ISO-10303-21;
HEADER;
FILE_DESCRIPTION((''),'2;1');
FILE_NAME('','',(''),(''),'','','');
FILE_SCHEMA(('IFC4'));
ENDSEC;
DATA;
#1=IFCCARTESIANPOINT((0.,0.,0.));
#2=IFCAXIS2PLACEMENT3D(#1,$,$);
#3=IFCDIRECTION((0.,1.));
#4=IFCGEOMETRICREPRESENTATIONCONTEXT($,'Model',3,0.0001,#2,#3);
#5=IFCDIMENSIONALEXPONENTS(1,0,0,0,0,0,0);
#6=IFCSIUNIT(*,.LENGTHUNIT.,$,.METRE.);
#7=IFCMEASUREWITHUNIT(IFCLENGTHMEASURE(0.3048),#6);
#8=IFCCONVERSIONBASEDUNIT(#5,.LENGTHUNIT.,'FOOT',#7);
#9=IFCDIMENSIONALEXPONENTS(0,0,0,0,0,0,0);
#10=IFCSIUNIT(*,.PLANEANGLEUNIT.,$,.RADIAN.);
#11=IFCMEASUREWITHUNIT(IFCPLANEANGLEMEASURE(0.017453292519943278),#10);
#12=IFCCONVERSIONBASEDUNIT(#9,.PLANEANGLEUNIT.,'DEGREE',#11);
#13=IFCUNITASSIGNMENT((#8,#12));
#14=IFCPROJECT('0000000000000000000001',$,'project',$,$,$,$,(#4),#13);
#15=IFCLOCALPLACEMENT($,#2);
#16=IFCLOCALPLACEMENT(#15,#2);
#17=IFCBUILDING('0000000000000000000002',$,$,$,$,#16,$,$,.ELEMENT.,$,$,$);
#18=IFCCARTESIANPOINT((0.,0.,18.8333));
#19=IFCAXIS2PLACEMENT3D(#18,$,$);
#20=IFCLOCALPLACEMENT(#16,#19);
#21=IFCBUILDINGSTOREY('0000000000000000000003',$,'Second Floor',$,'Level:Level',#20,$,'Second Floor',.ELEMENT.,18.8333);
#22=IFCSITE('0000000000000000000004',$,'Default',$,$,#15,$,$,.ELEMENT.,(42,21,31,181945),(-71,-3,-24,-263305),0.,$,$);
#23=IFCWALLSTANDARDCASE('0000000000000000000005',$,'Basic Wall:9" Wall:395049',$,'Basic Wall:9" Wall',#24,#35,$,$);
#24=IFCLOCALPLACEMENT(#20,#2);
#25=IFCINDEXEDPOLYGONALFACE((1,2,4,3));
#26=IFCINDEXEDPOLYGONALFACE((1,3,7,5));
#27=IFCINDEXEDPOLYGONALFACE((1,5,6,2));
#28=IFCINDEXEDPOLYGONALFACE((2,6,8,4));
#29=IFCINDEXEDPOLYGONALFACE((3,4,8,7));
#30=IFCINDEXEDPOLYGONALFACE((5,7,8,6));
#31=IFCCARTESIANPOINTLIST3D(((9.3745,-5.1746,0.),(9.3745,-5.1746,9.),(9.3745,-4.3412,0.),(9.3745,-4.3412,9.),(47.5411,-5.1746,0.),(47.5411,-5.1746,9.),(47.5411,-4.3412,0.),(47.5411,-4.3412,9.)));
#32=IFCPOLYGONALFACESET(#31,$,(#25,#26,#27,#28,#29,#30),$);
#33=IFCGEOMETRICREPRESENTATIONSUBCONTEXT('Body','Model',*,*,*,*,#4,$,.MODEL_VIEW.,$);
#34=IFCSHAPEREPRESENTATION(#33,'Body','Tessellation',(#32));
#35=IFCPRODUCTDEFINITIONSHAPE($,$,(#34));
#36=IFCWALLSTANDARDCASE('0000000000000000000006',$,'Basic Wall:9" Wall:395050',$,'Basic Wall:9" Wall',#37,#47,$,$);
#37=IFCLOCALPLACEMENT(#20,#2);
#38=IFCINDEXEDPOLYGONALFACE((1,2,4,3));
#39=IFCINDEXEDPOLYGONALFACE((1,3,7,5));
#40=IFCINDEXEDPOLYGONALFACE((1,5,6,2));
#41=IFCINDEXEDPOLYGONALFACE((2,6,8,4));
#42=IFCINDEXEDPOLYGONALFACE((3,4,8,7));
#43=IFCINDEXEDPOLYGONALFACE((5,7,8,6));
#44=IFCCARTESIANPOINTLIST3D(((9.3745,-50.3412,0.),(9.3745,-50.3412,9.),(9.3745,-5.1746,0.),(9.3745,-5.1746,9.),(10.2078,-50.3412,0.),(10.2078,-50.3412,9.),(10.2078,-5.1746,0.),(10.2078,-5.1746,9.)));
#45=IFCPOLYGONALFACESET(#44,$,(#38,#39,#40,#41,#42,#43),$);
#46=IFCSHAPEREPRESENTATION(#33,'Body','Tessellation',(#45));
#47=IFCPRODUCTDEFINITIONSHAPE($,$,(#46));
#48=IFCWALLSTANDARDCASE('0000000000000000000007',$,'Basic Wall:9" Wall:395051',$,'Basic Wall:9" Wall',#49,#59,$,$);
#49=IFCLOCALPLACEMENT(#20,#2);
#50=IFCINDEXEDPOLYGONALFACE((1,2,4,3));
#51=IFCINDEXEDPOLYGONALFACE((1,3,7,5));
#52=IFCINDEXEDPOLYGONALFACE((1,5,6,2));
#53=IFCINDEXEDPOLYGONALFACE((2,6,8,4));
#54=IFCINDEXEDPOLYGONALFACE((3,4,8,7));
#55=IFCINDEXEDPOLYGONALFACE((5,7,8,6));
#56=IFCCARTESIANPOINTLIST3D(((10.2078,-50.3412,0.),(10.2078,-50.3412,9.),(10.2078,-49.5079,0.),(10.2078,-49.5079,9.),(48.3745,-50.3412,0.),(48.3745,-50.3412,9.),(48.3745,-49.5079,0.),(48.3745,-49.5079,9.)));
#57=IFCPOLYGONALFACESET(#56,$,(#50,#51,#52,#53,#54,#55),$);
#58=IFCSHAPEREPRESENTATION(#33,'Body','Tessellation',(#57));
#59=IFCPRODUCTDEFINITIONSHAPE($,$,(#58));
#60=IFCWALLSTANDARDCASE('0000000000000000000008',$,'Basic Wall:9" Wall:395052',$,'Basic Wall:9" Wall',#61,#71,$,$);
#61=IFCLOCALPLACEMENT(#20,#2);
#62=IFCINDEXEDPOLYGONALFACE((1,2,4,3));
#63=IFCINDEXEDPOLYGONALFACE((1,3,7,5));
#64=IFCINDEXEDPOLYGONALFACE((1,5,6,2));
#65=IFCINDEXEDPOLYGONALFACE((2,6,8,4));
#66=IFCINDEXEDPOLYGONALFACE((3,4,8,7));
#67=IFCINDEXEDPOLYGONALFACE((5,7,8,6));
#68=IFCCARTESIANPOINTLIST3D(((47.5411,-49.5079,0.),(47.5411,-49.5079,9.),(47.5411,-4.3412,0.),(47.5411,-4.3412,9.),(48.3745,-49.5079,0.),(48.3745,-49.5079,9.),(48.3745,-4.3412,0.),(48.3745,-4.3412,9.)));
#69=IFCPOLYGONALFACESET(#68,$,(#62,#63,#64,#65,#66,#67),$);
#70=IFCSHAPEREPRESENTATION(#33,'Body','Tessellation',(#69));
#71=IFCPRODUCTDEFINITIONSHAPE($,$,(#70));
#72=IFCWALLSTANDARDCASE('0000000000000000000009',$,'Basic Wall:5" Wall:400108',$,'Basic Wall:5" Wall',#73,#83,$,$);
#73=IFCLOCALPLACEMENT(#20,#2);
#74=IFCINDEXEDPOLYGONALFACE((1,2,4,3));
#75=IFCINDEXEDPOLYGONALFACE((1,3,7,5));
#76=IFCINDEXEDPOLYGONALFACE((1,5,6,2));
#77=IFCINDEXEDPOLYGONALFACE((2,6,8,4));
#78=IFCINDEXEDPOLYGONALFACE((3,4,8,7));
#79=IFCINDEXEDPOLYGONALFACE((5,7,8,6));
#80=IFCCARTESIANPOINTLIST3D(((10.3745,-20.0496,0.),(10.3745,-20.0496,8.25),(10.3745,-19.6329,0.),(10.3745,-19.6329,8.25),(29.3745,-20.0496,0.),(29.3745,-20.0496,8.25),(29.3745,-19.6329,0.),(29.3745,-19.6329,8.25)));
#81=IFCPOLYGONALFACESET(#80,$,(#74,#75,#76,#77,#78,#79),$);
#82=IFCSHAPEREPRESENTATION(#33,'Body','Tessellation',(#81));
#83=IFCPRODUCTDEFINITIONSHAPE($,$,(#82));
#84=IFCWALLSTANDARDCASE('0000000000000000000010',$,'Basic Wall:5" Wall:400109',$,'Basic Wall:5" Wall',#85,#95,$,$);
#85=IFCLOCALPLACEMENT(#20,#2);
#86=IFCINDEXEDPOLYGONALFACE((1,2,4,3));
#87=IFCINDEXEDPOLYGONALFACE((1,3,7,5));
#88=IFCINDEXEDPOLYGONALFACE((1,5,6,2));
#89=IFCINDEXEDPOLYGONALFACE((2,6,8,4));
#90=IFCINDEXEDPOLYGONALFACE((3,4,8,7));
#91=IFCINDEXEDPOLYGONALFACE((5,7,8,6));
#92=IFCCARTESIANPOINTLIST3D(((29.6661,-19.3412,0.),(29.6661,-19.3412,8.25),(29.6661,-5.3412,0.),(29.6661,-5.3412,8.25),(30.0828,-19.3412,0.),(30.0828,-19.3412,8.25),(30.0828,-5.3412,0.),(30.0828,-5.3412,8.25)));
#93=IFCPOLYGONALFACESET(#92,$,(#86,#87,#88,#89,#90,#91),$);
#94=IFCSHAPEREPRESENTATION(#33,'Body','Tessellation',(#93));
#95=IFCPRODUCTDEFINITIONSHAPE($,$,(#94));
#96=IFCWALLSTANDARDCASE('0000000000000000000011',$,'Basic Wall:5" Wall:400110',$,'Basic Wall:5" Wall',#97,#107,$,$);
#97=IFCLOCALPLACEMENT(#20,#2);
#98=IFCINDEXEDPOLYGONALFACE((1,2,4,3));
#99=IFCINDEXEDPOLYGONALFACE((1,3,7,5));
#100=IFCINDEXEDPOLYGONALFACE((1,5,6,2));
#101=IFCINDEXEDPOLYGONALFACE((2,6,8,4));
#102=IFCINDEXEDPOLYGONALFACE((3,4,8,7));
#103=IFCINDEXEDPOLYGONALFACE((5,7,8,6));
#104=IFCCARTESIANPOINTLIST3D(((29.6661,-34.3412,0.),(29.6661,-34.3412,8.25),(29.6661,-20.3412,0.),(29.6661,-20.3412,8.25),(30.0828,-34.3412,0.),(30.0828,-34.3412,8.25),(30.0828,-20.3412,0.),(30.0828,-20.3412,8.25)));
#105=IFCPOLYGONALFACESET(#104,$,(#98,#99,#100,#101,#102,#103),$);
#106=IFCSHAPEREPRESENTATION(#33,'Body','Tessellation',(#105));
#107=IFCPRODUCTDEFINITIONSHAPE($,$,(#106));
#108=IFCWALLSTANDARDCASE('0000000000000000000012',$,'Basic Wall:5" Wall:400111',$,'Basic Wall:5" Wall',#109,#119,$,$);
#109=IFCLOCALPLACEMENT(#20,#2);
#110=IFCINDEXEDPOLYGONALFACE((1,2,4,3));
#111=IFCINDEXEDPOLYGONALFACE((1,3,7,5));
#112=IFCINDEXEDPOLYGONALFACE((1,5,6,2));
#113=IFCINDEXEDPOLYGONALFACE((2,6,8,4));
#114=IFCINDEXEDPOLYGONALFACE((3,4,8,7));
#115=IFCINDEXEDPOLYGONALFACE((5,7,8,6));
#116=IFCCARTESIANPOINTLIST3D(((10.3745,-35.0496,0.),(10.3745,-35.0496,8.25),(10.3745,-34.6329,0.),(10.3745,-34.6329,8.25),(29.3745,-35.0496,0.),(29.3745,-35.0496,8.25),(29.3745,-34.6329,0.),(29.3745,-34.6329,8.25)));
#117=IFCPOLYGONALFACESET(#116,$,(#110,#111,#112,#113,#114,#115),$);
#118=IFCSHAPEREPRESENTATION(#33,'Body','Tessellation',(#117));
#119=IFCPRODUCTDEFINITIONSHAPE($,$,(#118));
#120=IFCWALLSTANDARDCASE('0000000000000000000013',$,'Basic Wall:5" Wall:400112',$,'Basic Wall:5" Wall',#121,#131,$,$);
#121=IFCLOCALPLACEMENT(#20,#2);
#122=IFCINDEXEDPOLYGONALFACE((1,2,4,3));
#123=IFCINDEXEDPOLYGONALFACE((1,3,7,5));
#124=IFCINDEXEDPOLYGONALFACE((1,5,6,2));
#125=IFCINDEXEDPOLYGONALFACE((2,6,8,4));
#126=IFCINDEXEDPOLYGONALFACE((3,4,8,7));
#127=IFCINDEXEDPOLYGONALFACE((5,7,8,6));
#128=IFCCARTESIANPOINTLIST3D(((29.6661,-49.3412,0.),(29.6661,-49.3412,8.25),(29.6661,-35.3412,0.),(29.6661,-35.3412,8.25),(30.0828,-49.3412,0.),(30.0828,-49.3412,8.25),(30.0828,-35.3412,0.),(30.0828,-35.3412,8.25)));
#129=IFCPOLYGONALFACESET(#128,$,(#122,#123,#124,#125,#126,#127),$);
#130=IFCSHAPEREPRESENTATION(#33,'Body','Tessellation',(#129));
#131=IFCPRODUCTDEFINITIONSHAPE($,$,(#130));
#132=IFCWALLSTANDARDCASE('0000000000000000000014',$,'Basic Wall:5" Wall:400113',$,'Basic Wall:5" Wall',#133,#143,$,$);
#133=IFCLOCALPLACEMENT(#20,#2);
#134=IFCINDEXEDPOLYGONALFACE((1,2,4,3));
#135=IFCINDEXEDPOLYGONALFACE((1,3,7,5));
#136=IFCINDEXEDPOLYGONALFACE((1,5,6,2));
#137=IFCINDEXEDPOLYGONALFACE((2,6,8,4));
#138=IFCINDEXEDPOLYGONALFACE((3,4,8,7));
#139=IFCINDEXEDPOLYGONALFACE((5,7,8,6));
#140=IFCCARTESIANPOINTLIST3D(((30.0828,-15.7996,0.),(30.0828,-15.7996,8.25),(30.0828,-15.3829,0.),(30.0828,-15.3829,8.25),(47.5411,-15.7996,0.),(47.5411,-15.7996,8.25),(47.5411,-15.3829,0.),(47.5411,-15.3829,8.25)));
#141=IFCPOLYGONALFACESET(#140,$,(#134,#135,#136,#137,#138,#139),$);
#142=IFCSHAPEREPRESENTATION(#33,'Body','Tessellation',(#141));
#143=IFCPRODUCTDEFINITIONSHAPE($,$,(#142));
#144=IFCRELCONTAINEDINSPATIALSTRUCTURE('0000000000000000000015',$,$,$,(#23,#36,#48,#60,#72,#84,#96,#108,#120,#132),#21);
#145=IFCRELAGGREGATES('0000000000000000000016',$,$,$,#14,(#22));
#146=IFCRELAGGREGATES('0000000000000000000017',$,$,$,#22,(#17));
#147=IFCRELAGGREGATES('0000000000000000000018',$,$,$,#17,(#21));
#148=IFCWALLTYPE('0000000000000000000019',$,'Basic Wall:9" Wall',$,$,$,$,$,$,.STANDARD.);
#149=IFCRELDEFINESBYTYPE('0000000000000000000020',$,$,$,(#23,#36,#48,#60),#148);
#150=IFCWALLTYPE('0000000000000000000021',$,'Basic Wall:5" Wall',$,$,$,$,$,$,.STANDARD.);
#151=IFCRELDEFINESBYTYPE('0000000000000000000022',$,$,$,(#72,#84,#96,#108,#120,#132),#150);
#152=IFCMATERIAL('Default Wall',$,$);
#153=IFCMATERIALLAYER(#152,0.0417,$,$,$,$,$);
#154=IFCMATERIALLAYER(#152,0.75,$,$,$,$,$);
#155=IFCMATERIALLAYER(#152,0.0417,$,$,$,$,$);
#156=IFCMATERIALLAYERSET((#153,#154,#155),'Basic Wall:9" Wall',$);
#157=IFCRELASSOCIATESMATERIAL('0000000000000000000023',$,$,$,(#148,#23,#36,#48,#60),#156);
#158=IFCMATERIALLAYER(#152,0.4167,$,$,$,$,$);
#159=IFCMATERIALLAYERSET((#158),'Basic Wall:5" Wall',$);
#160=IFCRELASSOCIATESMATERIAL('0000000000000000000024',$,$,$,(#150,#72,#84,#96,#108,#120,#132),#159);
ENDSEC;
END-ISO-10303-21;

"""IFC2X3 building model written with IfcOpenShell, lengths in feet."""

from ifc_helpers import new_model, entity, si_unit, converted_unit, direction, frame, frame_2d, origin, place, context, subcontext, project, spatial, rectangle, extrude, material, layer, layer_set, layer_usage, type_object, element, save


model = new_model("IFC2X3")

# Units and contexts
model_context = context("Model", 3, precision=0.0001, world=origin(), true_north=direction((0.0, 1.0)))
body_context = subcontext(model_context, "Body", "Model", "MODEL_VIEW")
ifc_project = project(units=[converted_unit("LENGTHUNIT", "FOOT", entity("IfcLengthMeasure", 0.3048), si_unit("LENGTHUNIT", "METRE"), dimensions=[1, 0, 0, 0, 0, 0, 0]), converted_unit("PLANEANGLEUNIT", "DEGREE", entity("IfcPlaneAngleMeasure", 0.017453292519943278), si_unit("PLANEANGLEUNIT", "RADIAN"), dimensions=[0, 0, 0, 0, 0, 0, 0])], contexts=[model_context])

# Site, building, storey
site_placement = place(None, origin())
site = spatial("IfcSite", under=ifc_project, at=site_placement, Name="Default", CompositionType="ELEMENT", RefLatitude=(42, 21, 31, 181945), RefLongitude=(-71, -3, -24, -263305), RefElevation=0.0)
building_placement = place(site_placement, origin())
building = spatial("IfcBuilding", under=site, at=building_placement, CompositionType="ELEMENT")
storey_placement = place(building_placement, frame((0.0, 0.0, 18.8333)))
storey = spatial("IfcBuildingStorey", under=building, at=storey_placement, Name="Second Floor", ObjectType="Level:Level", LongName="Second Floor", CompositionType="ELEMENT", Elevation=18.8333)

# Walls
ifc_material_1 = material(Name="Default Wall")
ifc_layer_1 = layer(ifc_material_1, 0.0417)
ifc_layer_2 = layer(ifc_material_1, 0.75)
ifc_layer_3 = layer(ifc_material_1, 0.0417)
ifc_layer_set_1 = layer_set([ifc_layer_1, ifc_layer_2, ifc_layer_3], Name="Basic Wall:9\" Wall")
ifc_layer_usage_1 = layer_usage(ifc_layer_set_1, "AXIS2", "NEGATIVE", 0.4167)
wall_type_1 = type_object("IfcWallType", Name="Basic Wall:9\" Wall", PredefinedType="STANDARD", material=ifc_layer_set_1)
wall_1_placement = place(storey_placement, frame((9.3745, -4.7579, 0.0)))
element("IfcWallStandardCase", 1, at=wall_1_placement, inside=storey, type_object=wall_type_1, material=ifc_layer_usage_1, Name="Basic Wall:9\" Wall:395049", ObjectType="Basic Wall:9\" Wall", context=body_context, shape_type="SweptSolid", body=[
    extrude(rectangle(XDim=38.1667, YDim=0.8333, at=frame_2d((19.0833, 0.0), x_axis=(-1.0, 0.0))), origin(), (0.0, 0.0, 1.0), 9.0),
])
wall_2_placement = place(storey_placement, frame((9.7911, -50.3412, 0.0), z_axis=(0.0, 0.0, 1.0), x_axis=(0.0, 1.0, 0.0)))
element("IfcWallStandardCase", 2, at=wall_2_placement, inside=storey, type_object=wall_type_1, material=ifc_layer_usage_1, Name="Basic Wall:9\" Wall:395050", ObjectType="Basic Wall:9\" Wall", context=body_context, shape_type="SweptSolid", body=[
    extrude(rectangle(XDim=45.1667, YDim=0.8333, at=frame_2d((22.5833, 0.0), x_axis=(-1.0, 0.0))), origin(), (0.0, 0.0, 1.0), 9.0),
])
wall_3_placement = place(storey_placement, frame((48.3745, -49.9246, 0.0), z_axis=(0.0, 0.0, 1.0), x_axis=(-1.0, 0.0, 0.0)))
element("IfcWallStandardCase", 3, at=wall_3_placement, inside=storey, type_object=wall_type_1, material=ifc_layer_usage_1, Name="Basic Wall:9\" Wall:395051", ObjectType="Basic Wall:9\" Wall", context=body_context, shape_type="SweptSolid", body=[
    extrude(rectangle(XDim=38.1667, YDim=0.8333, at=frame_2d((19.0833, 0.0), x_axis=(-1.0, 0.0))), origin(), (0.0, 0.0, 1.0), 9.0),
])
wall_4_placement = place(storey_placement, frame((47.9578, -4.3412, 0.0), z_axis=(0.0, 0.0, 1.0), x_axis=(0.0, -1.0, 0.0)))
element("IfcWallStandardCase", 4, at=wall_4_placement, inside=storey, type_object=wall_type_1, material=ifc_layer_usage_1, Name="Basic Wall:9\" Wall:395052", ObjectType="Basic Wall:9\" Wall", context=body_context, shape_type="SweptSolid", body=[
    extrude(rectangle(XDim=45.1667, YDim=0.8333, at=frame_2d((22.5833, 0.0), x_axis=(-1.0, 0.0))), origin(), (0.0, 0.0, 1.0), 9.0),
])
ifc_layer_4 = layer(ifc_material_1, 0.4167)
ifc_layer_set_2 = layer_set([ifc_layer_4], Name="Basic Wall:5\" Wall")
ifc_layer_usage_2 = layer_usage(ifc_layer_set_2, "AXIS2", "NEGATIVE", 0.2083)
wall_type_2 = type_object("IfcWallType", Name="Basic Wall:5\" Wall", PredefinedType="STANDARD", material=ifc_layer_set_2)
wall_5_placement = place(storey_placement, frame((10.3745, -19.8412, 0.0)))
element("IfcWallStandardCase", 5, at=wall_5_placement, inside=storey, type_object=wall_type_2, material=ifc_layer_usage_2, Name="Basic Wall:5\" Wall:400108", ObjectType="Basic Wall:5\" Wall", context=body_context, shape_type="SweptSolid", body=[
    extrude(rectangle(XDim=19.0, YDim=0.4167, at=frame_2d((9.5, 0.0), x_axis=(-1.0, 0.0))), origin(), (0.0, 0.0, 1.0), 8.25),
])
wall_6_placement = place(storey_placement, frame((29.8745, -19.3412, 0.0), z_axis=(0.0, 0.0, 1.0), x_axis=(0.0, 1.0, 0.0)))
element("IfcWallStandardCase", 6, at=wall_6_placement, inside=storey, type_object=wall_type_2, material=ifc_layer_usage_2, Name="Basic Wall:5\" Wall:400109", ObjectType="Basic Wall:5\" Wall", context=body_context, shape_type="SweptSolid", body=[
    extrude(rectangle(XDim=14.0, YDim=0.4167, at=frame_2d((7.0, 0.0), x_axis=(-1.0, 0.0))), origin(), (0.0, 0.0, 1.0), 8.25),
])
wall_7_placement = place(storey_placement, frame((29.8745, -20.3412, 0.0), z_axis=(0.0, 0.0, 1.0), x_axis=(0.0, -1.0, 0.0)))
element("IfcWallStandardCase", 7, at=wall_7_placement, inside=storey, type_object=wall_type_2, material=ifc_layer_usage_2, Name="Basic Wall:5\" Wall:400110", ObjectType="Basic Wall:5\" Wall", context=body_context, shape_type="SweptSolid", body=[
    extrude(rectangle(XDim=14.0, YDim=0.4167, at=frame_2d((7.0, 0.0), x_axis=(-1.0, 0.0))), origin(), (0.0, 0.0, 1.0), 8.25),
])
wall_8_placement = place(storey_placement, frame((29.3745, -34.8412, 0.0), z_axis=(0.0, 0.0, 1.0), x_axis=(-1.0, 0.0, 0.0)))
element("IfcWallStandardCase", 8, at=wall_8_placement, inside=storey, type_object=wall_type_2, material=ifc_layer_usage_2, Name="Basic Wall:5\" Wall:400111", ObjectType="Basic Wall:5\" Wall", context=body_context, shape_type="SweptSolid", body=[
    extrude(rectangle(XDim=19.0, YDim=0.4167, at=frame_2d((9.5, 0.0), x_axis=(-1.0, 0.0))), origin(), (0.0, 0.0, 1.0), 8.25),
])
wall_9_placement = place(storey_placement, frame((29.8745, -35.3412, 0.0), z_axis=(0.0, 0.0, 1.0), x_axis=(0.0, -1.0, 0.0)))
element("IfcWallStandardCase", 9, at=wall_9_placement, inside=storey, type_object=wall_type_2, material=ifc_layer_usage_2, Name="Basic Wall:5\" Wall:400112", ObjectType="Basic Wall:5\" Wall", context=body_context, shape_type="SweptSolid", body=[
    extrude(rectangle(XDim=14.0, YDim=0.4167, at=frame_2d((7.0, 0.0), x_axis=(-1.0, 0.0))), origin(), (0.0, 0.0, 1.0), 8.25),
])
wall_10_placement = place(storey_placement, frame((30.0828, -15.5912, 0.0)))
element("IfcWallStandardCase", 10, at=wall_10_placement, inside=storey, type_object=wall_type_2, material=ifc_layer_usage_2, Name="Basic Wall:5\" Wall:400113", ObjectType="Basic Wall:5\" Wall", context=body_context, shape_type="SweptSolid", body=[
    extrude(rectangle(XDim=17.4583, YDim=0.4167, at=frame_2d((8.7292, 0.0), x_axis=(-1.0, 0.0))), origin(), (0.0, 0.0, 1.0), 8.25),
])

save(model, "model.ifc")
